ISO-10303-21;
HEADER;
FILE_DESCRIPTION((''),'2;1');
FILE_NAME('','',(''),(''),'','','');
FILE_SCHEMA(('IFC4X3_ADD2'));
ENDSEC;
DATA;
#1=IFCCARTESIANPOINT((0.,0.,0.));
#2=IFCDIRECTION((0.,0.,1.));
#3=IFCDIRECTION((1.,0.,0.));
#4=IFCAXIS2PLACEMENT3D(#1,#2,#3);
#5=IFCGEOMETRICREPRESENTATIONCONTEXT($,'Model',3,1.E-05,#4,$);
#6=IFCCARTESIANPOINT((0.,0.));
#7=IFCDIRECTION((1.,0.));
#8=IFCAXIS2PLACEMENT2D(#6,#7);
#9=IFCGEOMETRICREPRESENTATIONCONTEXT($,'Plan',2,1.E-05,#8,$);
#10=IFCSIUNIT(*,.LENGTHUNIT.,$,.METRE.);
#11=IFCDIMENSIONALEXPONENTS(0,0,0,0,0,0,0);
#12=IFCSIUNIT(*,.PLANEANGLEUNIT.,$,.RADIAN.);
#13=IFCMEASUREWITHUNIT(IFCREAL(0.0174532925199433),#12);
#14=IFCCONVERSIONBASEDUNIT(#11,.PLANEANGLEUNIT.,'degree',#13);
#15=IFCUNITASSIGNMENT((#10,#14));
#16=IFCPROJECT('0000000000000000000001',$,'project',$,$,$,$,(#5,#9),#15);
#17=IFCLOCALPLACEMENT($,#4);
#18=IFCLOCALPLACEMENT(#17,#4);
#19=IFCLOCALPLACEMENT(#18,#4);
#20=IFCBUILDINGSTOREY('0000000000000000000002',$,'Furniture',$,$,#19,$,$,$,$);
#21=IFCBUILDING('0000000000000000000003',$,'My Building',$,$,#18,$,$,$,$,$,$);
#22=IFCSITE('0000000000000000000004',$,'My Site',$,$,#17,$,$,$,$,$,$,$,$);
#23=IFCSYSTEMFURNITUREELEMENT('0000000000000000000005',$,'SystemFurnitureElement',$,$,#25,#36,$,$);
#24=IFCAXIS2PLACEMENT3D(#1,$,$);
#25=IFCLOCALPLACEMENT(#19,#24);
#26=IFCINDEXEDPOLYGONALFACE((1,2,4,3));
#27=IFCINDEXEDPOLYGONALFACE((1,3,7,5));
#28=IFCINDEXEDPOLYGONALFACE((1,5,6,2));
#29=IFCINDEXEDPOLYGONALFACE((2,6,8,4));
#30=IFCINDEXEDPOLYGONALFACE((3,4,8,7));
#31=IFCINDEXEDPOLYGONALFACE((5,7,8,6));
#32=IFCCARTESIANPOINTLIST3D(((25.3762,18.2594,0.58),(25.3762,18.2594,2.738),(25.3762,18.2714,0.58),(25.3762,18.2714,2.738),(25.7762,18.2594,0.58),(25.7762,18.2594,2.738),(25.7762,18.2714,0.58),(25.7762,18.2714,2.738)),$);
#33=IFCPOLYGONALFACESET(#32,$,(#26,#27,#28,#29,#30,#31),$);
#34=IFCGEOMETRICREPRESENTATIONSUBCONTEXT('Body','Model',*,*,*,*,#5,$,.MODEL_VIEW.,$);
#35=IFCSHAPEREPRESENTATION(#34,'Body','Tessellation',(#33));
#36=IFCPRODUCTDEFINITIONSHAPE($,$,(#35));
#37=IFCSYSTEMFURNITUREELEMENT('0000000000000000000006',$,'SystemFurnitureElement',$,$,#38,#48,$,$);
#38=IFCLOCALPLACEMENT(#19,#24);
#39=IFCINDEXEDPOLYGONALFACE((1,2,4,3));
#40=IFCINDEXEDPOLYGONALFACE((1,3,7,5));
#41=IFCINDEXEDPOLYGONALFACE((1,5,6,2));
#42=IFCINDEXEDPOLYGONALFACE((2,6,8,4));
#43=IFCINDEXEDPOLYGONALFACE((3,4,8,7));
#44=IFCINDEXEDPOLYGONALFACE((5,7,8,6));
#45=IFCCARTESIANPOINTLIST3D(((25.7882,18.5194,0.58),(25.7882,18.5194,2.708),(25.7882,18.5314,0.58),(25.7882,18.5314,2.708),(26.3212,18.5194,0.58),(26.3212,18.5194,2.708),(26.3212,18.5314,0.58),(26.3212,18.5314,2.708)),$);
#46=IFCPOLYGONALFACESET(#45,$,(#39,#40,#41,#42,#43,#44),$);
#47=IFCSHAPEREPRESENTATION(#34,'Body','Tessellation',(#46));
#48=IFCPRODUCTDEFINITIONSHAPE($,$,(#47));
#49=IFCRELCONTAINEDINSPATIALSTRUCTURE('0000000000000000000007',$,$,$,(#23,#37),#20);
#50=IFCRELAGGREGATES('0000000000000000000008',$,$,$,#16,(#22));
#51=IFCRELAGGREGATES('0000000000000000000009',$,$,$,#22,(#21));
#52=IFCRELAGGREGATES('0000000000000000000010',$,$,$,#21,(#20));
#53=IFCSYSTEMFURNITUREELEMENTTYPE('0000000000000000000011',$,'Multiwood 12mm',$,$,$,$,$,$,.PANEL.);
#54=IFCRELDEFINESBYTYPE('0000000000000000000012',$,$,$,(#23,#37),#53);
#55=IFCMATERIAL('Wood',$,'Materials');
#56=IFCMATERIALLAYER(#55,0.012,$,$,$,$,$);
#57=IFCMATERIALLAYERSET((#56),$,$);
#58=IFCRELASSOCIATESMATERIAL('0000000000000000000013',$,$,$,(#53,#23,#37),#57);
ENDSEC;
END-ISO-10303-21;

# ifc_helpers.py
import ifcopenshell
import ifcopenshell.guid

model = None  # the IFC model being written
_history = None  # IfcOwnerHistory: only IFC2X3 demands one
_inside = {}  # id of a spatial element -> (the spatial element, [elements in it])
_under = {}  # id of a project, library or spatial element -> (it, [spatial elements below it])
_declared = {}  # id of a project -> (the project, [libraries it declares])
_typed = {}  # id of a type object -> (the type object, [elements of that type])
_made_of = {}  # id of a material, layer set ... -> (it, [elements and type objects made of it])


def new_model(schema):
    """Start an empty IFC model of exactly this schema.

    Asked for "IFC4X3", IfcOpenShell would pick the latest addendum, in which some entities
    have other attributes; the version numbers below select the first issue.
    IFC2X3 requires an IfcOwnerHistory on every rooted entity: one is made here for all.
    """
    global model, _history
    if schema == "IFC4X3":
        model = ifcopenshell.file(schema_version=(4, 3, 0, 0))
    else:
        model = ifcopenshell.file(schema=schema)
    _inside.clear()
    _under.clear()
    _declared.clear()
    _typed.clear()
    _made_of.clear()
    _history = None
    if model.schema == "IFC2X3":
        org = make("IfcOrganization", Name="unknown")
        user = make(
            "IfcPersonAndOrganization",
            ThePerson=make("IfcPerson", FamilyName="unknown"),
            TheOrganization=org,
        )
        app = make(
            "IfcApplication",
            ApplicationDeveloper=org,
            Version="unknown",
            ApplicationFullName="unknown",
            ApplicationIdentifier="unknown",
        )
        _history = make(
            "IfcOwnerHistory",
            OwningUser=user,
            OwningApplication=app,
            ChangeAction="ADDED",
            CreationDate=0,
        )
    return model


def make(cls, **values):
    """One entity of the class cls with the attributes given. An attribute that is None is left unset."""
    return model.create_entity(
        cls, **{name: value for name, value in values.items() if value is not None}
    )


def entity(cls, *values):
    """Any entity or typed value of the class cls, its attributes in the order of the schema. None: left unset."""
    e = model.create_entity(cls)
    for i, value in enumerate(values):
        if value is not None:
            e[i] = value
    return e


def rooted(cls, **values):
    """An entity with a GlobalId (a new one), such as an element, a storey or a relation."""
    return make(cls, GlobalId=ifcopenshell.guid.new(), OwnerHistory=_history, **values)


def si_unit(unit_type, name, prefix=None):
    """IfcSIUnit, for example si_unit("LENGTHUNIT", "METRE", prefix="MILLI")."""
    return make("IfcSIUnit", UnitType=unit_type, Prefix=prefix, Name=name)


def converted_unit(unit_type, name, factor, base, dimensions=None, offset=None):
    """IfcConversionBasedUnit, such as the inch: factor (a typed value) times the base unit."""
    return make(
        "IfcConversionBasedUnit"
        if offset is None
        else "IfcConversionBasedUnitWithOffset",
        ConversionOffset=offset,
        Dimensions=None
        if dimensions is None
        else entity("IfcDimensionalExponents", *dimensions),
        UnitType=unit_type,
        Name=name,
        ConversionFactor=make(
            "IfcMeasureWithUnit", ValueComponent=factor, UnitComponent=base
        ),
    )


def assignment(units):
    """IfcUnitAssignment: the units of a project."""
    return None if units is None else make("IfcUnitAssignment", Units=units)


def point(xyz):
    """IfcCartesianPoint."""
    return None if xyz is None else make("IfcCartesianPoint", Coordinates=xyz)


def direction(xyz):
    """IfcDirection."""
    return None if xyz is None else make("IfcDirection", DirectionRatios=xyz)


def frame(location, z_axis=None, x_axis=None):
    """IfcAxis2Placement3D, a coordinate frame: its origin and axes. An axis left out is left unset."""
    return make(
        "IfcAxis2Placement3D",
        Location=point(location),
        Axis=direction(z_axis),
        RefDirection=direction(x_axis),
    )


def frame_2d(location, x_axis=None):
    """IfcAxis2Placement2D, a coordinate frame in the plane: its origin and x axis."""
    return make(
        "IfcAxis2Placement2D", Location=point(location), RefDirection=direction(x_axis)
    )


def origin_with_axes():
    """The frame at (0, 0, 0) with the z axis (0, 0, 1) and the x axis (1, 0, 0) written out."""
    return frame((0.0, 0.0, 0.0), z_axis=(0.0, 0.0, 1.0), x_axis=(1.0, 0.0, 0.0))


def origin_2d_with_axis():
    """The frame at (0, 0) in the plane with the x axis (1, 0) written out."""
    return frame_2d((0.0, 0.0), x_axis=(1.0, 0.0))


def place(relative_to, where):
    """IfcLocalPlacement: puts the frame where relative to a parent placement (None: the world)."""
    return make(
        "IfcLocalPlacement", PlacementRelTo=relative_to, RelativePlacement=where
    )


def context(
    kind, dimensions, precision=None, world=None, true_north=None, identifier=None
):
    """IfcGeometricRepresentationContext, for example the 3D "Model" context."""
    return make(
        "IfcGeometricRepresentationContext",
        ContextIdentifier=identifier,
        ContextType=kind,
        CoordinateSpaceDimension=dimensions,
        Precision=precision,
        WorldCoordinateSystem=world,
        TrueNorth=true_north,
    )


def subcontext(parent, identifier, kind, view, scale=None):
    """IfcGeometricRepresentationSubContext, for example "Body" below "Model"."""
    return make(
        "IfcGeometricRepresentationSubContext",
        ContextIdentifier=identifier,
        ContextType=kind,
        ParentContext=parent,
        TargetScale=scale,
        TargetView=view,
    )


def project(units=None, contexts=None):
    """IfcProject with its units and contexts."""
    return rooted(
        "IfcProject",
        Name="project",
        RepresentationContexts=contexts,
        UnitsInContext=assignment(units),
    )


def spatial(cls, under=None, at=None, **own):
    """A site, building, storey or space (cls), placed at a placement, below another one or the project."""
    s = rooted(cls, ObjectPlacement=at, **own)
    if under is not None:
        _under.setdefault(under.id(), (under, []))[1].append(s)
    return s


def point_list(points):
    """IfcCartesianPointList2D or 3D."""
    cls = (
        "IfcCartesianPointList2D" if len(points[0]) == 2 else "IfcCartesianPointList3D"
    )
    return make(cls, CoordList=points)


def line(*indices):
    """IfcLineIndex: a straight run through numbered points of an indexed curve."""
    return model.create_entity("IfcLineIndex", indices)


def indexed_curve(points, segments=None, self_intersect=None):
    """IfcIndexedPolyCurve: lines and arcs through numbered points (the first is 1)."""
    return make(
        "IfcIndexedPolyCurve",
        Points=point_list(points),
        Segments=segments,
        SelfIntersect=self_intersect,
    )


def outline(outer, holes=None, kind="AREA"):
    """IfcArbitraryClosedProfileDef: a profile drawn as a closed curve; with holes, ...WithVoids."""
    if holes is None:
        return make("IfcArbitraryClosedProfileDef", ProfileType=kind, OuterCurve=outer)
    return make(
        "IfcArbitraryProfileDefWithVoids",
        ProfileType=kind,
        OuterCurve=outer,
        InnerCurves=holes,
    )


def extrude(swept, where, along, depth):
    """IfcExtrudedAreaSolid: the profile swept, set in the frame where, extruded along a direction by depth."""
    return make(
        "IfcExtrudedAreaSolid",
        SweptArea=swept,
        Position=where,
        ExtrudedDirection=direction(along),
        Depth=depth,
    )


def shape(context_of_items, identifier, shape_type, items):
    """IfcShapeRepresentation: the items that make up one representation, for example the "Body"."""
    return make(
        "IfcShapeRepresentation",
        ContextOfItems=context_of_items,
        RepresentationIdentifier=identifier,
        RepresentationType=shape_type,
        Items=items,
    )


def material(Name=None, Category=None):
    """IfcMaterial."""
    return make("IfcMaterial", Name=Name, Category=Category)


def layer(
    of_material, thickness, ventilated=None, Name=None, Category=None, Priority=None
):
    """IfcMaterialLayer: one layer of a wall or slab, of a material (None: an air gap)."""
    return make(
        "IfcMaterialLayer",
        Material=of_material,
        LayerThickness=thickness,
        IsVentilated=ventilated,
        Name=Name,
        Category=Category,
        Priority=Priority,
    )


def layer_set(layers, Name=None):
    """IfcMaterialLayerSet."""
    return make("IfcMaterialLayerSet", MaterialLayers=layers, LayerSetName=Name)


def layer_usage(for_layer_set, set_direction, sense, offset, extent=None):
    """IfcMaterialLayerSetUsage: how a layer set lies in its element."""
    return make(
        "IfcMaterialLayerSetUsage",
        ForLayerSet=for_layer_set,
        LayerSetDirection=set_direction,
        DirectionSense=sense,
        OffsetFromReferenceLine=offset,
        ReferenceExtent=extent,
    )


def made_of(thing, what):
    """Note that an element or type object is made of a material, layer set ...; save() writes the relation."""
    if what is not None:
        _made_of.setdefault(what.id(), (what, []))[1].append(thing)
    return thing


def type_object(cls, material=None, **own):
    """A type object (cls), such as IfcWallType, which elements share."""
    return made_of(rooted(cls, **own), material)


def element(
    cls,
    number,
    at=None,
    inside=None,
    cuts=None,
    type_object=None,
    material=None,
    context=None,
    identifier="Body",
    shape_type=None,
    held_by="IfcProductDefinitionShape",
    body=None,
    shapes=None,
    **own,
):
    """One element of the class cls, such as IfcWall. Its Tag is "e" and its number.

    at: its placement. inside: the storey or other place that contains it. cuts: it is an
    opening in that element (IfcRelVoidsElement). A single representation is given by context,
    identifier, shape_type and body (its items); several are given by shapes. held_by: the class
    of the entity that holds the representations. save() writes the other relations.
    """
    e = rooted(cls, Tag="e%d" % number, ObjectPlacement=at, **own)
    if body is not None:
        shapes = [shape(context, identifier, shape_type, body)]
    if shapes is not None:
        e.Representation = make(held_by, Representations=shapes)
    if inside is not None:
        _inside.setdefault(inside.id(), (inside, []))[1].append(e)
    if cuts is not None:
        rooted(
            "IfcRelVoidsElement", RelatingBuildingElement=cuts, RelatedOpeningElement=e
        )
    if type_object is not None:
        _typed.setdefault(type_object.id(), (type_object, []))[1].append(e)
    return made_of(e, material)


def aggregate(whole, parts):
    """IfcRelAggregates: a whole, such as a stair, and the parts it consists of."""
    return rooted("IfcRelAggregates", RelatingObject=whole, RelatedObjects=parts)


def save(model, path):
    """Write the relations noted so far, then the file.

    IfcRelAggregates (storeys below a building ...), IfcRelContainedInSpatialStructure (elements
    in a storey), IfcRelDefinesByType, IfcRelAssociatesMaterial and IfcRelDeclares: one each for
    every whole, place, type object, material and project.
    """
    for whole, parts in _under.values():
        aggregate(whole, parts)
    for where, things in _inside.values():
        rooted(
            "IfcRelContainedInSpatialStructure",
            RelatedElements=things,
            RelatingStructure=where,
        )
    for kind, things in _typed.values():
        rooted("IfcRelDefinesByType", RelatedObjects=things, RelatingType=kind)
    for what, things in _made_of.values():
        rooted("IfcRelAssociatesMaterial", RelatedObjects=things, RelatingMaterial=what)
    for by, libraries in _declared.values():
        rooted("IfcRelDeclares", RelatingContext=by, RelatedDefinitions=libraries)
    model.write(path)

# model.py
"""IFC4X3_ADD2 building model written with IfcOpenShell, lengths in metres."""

from ifc_helpers import new_model, entity, si_unit, converted_unit, frame, origin_with_axes, origin_2d_with_axis, place, context, subcontext, project, spatial, line, indexed_curve, outline, extrude, material, layer, layer_set, layer_usage, type_object, element, save


model = new_model("IFC4X3_ADD2")

# Units and contexts
model_context = context("Model", 3, precision=1e-05, world=origin_with_axes())
plan_context = context("Plan", 2, precision=1e-05, world=origin_2d_with_axis())
body_context = subcontext(model_context, "Body", "Model", "MODEL_VIEW")
ifc_project = project(units=[si_unit("LENGTHUNIT", "METRE"), converted_unit("PLANEANGLEUNIT", "degree", entity("IfcReal", 0.0174532925199433), si_unit("PLANEANGLEUNIT", "RADIAN"), dimensions=[0, 0, 0, 0, 0, 0, 0])], contexts=[model_context, plan_context])

# Site, building, storey
site_placement = place(None, origin_with_axes())
site = spatial("IfcSite", under=ifc_project, at=site_placement, Name="My Site")
building_placement = place(site_placement, origin_with_axes())
building = spatial("IfcBuilding", under=site, at=building_placement, Name="My Building")
storey_placement = place(building_placement, origin_with_axes())
storey = spatial("IfcBuildingStorey", under=building, at=storey_placement, Name="Furniture")

# System furniture elements
ifc_material = material(Name="Wood", Category="Materials")
ifc_layer_1 = layer(ifc_material, 0.012)
ifc_layer_set_1 = layer_set([ifc_layer_1])
system_furniture_element_type_1 = type_object("IfcSystemFurnitureElementType", Name="Multiwood 12mm", PredefinedType="PANEL", material=ifc_layer_set_1)
ifc_layer_usage_1 = layer_usage(ifc_layer_set_1, "AXIS2", "POSITIVE", 0.0)
system_furniture_element_1_placement = place(storey_placement, frame((25.7762, 18.2714, 0.58), z_axis=(0.0, 0.0, 1.0), x_axis=(-1.0, 0.0, 0.0)))
element("IfcSystemFurnitureElement", 1, at=system_furniture_element_1_placement, inside=storey, type_object=system_furniture_element_type_1, material=ifc_layer_usage_1, Name="SystemFurnitureElement", context=body_context, shape_type="SweptSolid", body=[
    extrude(outline(indexed_curve([(0.0, 0.0), (0.0, 0.012), (0.4, 0.012), (0.4, 0.0)], segments=[line(1, 2, 3, 4, 1)])), origin_with_axes(), (0.0, 0.0, 1.0), 2.158),
])
ifc_layer_usage_2 = layer_usage(ifc_layer_set_1, "AXIS2", "POSITIVE", 0.0)
system_furniture_element_2_placement = place(storey_placement, frame((26.3212, 18.5314, 0.58), z_axis=(0.0, 0.0, 1.0), x_axis=(-1.0, 0.0, 0.0)))
element("IfcSystemFurnitureElement", 2, at=system_furniture_element_2_placement, inside=storey, type_object=system_furniture_element_type_1, material=ifc_layer_usage_2, Name="SystemFurnitureElement", context=body_context, shape_type="SweptSolid", body=[
    extrude(outline(indexed_curve([(0.0, 0.0), (0.0, 0.012), (0.533, 0.012), (0.533, 0.0)], segments=[line(1, 2, 3, 4, 1)])), origin_with_axes(), (0.0, 0.0, 1.0), 2.128),
])

save(model, "model.ifc")
